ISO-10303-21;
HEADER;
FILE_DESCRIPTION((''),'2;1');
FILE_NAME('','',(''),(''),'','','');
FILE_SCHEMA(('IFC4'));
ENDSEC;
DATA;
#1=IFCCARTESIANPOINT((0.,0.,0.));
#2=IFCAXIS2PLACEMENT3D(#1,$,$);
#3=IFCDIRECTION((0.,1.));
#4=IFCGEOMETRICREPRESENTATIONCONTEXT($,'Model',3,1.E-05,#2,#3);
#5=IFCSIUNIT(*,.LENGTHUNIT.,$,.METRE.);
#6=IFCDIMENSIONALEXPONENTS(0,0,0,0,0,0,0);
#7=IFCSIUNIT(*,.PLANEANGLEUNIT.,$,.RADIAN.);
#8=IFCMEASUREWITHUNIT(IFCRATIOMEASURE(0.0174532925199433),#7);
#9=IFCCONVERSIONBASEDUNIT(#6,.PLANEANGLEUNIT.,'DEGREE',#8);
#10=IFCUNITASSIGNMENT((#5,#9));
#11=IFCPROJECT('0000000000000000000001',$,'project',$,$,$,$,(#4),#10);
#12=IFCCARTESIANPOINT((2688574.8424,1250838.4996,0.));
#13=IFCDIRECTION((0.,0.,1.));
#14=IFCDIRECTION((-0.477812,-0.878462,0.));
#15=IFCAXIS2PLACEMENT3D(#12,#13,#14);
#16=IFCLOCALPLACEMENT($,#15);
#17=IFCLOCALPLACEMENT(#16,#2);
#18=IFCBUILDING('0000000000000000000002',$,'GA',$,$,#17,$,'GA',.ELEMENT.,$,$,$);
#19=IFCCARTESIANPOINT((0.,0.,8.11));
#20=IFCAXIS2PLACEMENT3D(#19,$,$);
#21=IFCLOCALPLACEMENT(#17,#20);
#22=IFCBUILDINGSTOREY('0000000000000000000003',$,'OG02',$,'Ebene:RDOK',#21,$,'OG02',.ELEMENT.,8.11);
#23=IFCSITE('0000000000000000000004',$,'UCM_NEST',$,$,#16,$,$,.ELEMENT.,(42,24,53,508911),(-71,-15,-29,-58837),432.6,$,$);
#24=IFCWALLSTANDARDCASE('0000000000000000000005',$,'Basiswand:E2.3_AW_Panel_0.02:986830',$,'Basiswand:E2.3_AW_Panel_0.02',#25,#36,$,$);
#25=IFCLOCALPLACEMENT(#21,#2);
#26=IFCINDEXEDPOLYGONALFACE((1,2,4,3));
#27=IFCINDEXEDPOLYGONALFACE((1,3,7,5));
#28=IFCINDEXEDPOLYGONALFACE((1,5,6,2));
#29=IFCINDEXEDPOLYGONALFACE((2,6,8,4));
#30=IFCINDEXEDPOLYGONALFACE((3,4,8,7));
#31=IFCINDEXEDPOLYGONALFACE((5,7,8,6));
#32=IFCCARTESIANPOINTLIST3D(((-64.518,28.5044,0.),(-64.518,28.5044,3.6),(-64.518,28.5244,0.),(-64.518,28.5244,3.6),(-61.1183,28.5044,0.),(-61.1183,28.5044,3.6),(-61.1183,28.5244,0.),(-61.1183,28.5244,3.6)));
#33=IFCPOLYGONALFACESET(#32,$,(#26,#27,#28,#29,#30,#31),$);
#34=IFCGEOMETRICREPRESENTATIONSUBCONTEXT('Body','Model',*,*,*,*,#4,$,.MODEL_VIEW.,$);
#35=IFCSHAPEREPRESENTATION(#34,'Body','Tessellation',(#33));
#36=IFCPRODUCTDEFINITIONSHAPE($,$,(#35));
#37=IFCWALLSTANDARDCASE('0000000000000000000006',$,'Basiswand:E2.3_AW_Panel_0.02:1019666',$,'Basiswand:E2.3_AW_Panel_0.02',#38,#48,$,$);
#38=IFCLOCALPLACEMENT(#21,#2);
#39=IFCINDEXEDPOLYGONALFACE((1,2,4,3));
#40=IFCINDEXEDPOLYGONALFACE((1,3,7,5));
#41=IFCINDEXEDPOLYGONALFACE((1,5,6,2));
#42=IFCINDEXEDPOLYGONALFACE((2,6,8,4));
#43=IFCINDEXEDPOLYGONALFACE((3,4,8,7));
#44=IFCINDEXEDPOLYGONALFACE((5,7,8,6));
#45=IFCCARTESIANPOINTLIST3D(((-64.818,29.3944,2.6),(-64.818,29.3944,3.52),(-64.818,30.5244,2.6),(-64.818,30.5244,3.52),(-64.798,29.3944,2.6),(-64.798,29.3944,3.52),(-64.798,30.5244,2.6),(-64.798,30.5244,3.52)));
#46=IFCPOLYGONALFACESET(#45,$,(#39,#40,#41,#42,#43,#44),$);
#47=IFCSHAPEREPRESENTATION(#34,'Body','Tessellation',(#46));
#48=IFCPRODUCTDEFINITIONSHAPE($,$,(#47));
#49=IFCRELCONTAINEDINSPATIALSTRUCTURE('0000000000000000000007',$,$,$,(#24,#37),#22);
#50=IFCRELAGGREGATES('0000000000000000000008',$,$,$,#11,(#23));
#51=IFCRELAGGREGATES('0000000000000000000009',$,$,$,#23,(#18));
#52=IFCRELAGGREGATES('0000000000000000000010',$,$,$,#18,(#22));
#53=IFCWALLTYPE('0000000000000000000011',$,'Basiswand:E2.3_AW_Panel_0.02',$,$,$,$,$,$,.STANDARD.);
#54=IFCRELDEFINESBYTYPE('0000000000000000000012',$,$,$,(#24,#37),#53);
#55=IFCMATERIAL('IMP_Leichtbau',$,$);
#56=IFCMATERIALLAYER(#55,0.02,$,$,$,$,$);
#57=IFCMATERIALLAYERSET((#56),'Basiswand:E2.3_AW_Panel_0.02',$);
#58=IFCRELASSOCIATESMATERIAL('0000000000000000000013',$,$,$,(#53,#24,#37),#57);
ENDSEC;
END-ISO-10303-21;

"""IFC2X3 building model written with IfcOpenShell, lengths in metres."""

from ifc_helpers import new_model, entity, si_unit, converted_unit, direction, frame, frame_2d, origin, place, context, subcontext, project, spatial, polyline, rectangle, extrude, clip, bounded_halfspace, material, layer, layer_set, layer_usage, type_object, element, save


model = new_model("IFC2X3")

# Units and contexts
model_context = context("Model", 3, precision=1e-05, world=origin(), true_north=direction((0.0, 1.0)))
body_context = subcontext(model_context, "Body", "Model", "MODEL_VIEW")
ifc_project = project(units=[si_unit("LENGTHUNIT", "METRE"), converted_unit("PLANEANGLEUNIT", "DEGREE", entity("IfcRatioMeasure", 0.0174532925199433), si_unit("PLANEANGLEUNIT", "RADIAN"), dimensions=[0, 0, 0, 0, 0, 0, 0])], contexts=[model_context])

# Site, building, storey
site_placement = place(None, frame((2688574.8424, 1250838.4996, 0.0), z_axis=(0.0, 0.0, 1.0), x_axis=(-0.477812, -0.878462, 0.0)))
site = spatial("IfcSite", under=ifc_project, at=site_placement, Name="UCM_NEST", CompositionType="ELEMENT", RefLatitude=(42, 24, 53, 508911), RefLongitude=(-71, -15, -29, -58837), RefElevation=432.6)
building_placement = place(site_placement, origin())
building = spatial("IfcBuilding", under=site, at=building_placement, Name="GA", LongName="GA", CompositionType="ELEMENT")
storey_placement = place(building_placement, frame((0.0, 0.0, 8.11)))
storey = spatial("IfcBuildingStorey", under=building, at=storey_placement, Name="OG02", ObjectType="Ebene:RDOK", LongName="OG02", CompositionType="ELEMENT", Elevation=8.11)

# Walls
ifc_material_1 = material(Name="IMP_Leichtbau")
ifc_layer_1 = layer(ifc_material_1, 0.02)
ifc_layer_set_1 = layer_set([ifc_layer_1], Name="Basiswand:E2.3_AW_Panel_0.02")
wall_type_1 = type_object("IfcWallType", Name="Basiswand:E2.3_AW_Panel_0.02", PredefinedType="STANDARD", material=ifc_layer_set_1)
ifc_layer_usage_1 = layer_usage(ifc_layer_set_1, "AXIS2", "NEGATIVE", 0.01)
wall_1_placement = place(storey_placement, frame((-64.518, 28.5144, 0.0)))
element("IfcWallStandardCase", 1, at=wall_1_placement, inside=storey, type_object=wall_type_1, material=ifc_layer_usage_1, Name="Basiswand:E2.3_AW_Panel_0.02:986830", ObjectType="Basiswand:E2.3_AW_Panel_0.02", context=body_context, shape_type="SweptSolid", body=[
    extrude(rectangle(XDim=3.3997, YDim=0.02, at=frame_2d((1.6999, 0.0), x_axis=(-1.0, 0.0))), origin(), (0.0, 0.0, 1.0), 3.6),
])
ifc_layer_usage_2 = layer_usage(ifc_layer_set_1, "AXIS2", "NEGATIVE", 0.01)
wall_2_placement = place(storey_placement, frame((-64.808, 30.5244, 2.6), z_axis=(0.0, 0.0, 1.0), x_axis=(0.0, -1.0, 0.0)))
element("IfcWallStandardCase", 2, at=wall_2_placement, inside=storey, type_object=wall_type_1, material=ifc_layer_usage_2, Name="Basiswand:E2.3_AW_Panel_0.02:1019666", ObjectType="Basiswand:E2.3_AW_Panel_0.02", context=body_context, shape_type="Clipping", body=[
    clip(extrude(rectangle(XDim=1.13, YDim=0.02, at=frame_2d((0.565, 0.0), x_axis=(-1.0, 0.0))), origin(), (0.0, 0.0, 1.0), 0.92), bounded_halfspace(frame((0.0, -0.01, 0.92), z_axis=(0.0, 0.0, -1.0), x_axis=(0.0, -1.0, 0.0)), True, frame((0.0, -0.01, 0.92), z_axis=(0.0, 0.0, -1.0), x_axis=(0.0, -1.0, 0.0)), polyline([(0.0, 0.0), (-0.02, 0.0), (-0.02, -1.13), (0.0, -1.13), (0.0, 0.0)]))),
])

save(model, "model.ifc")
